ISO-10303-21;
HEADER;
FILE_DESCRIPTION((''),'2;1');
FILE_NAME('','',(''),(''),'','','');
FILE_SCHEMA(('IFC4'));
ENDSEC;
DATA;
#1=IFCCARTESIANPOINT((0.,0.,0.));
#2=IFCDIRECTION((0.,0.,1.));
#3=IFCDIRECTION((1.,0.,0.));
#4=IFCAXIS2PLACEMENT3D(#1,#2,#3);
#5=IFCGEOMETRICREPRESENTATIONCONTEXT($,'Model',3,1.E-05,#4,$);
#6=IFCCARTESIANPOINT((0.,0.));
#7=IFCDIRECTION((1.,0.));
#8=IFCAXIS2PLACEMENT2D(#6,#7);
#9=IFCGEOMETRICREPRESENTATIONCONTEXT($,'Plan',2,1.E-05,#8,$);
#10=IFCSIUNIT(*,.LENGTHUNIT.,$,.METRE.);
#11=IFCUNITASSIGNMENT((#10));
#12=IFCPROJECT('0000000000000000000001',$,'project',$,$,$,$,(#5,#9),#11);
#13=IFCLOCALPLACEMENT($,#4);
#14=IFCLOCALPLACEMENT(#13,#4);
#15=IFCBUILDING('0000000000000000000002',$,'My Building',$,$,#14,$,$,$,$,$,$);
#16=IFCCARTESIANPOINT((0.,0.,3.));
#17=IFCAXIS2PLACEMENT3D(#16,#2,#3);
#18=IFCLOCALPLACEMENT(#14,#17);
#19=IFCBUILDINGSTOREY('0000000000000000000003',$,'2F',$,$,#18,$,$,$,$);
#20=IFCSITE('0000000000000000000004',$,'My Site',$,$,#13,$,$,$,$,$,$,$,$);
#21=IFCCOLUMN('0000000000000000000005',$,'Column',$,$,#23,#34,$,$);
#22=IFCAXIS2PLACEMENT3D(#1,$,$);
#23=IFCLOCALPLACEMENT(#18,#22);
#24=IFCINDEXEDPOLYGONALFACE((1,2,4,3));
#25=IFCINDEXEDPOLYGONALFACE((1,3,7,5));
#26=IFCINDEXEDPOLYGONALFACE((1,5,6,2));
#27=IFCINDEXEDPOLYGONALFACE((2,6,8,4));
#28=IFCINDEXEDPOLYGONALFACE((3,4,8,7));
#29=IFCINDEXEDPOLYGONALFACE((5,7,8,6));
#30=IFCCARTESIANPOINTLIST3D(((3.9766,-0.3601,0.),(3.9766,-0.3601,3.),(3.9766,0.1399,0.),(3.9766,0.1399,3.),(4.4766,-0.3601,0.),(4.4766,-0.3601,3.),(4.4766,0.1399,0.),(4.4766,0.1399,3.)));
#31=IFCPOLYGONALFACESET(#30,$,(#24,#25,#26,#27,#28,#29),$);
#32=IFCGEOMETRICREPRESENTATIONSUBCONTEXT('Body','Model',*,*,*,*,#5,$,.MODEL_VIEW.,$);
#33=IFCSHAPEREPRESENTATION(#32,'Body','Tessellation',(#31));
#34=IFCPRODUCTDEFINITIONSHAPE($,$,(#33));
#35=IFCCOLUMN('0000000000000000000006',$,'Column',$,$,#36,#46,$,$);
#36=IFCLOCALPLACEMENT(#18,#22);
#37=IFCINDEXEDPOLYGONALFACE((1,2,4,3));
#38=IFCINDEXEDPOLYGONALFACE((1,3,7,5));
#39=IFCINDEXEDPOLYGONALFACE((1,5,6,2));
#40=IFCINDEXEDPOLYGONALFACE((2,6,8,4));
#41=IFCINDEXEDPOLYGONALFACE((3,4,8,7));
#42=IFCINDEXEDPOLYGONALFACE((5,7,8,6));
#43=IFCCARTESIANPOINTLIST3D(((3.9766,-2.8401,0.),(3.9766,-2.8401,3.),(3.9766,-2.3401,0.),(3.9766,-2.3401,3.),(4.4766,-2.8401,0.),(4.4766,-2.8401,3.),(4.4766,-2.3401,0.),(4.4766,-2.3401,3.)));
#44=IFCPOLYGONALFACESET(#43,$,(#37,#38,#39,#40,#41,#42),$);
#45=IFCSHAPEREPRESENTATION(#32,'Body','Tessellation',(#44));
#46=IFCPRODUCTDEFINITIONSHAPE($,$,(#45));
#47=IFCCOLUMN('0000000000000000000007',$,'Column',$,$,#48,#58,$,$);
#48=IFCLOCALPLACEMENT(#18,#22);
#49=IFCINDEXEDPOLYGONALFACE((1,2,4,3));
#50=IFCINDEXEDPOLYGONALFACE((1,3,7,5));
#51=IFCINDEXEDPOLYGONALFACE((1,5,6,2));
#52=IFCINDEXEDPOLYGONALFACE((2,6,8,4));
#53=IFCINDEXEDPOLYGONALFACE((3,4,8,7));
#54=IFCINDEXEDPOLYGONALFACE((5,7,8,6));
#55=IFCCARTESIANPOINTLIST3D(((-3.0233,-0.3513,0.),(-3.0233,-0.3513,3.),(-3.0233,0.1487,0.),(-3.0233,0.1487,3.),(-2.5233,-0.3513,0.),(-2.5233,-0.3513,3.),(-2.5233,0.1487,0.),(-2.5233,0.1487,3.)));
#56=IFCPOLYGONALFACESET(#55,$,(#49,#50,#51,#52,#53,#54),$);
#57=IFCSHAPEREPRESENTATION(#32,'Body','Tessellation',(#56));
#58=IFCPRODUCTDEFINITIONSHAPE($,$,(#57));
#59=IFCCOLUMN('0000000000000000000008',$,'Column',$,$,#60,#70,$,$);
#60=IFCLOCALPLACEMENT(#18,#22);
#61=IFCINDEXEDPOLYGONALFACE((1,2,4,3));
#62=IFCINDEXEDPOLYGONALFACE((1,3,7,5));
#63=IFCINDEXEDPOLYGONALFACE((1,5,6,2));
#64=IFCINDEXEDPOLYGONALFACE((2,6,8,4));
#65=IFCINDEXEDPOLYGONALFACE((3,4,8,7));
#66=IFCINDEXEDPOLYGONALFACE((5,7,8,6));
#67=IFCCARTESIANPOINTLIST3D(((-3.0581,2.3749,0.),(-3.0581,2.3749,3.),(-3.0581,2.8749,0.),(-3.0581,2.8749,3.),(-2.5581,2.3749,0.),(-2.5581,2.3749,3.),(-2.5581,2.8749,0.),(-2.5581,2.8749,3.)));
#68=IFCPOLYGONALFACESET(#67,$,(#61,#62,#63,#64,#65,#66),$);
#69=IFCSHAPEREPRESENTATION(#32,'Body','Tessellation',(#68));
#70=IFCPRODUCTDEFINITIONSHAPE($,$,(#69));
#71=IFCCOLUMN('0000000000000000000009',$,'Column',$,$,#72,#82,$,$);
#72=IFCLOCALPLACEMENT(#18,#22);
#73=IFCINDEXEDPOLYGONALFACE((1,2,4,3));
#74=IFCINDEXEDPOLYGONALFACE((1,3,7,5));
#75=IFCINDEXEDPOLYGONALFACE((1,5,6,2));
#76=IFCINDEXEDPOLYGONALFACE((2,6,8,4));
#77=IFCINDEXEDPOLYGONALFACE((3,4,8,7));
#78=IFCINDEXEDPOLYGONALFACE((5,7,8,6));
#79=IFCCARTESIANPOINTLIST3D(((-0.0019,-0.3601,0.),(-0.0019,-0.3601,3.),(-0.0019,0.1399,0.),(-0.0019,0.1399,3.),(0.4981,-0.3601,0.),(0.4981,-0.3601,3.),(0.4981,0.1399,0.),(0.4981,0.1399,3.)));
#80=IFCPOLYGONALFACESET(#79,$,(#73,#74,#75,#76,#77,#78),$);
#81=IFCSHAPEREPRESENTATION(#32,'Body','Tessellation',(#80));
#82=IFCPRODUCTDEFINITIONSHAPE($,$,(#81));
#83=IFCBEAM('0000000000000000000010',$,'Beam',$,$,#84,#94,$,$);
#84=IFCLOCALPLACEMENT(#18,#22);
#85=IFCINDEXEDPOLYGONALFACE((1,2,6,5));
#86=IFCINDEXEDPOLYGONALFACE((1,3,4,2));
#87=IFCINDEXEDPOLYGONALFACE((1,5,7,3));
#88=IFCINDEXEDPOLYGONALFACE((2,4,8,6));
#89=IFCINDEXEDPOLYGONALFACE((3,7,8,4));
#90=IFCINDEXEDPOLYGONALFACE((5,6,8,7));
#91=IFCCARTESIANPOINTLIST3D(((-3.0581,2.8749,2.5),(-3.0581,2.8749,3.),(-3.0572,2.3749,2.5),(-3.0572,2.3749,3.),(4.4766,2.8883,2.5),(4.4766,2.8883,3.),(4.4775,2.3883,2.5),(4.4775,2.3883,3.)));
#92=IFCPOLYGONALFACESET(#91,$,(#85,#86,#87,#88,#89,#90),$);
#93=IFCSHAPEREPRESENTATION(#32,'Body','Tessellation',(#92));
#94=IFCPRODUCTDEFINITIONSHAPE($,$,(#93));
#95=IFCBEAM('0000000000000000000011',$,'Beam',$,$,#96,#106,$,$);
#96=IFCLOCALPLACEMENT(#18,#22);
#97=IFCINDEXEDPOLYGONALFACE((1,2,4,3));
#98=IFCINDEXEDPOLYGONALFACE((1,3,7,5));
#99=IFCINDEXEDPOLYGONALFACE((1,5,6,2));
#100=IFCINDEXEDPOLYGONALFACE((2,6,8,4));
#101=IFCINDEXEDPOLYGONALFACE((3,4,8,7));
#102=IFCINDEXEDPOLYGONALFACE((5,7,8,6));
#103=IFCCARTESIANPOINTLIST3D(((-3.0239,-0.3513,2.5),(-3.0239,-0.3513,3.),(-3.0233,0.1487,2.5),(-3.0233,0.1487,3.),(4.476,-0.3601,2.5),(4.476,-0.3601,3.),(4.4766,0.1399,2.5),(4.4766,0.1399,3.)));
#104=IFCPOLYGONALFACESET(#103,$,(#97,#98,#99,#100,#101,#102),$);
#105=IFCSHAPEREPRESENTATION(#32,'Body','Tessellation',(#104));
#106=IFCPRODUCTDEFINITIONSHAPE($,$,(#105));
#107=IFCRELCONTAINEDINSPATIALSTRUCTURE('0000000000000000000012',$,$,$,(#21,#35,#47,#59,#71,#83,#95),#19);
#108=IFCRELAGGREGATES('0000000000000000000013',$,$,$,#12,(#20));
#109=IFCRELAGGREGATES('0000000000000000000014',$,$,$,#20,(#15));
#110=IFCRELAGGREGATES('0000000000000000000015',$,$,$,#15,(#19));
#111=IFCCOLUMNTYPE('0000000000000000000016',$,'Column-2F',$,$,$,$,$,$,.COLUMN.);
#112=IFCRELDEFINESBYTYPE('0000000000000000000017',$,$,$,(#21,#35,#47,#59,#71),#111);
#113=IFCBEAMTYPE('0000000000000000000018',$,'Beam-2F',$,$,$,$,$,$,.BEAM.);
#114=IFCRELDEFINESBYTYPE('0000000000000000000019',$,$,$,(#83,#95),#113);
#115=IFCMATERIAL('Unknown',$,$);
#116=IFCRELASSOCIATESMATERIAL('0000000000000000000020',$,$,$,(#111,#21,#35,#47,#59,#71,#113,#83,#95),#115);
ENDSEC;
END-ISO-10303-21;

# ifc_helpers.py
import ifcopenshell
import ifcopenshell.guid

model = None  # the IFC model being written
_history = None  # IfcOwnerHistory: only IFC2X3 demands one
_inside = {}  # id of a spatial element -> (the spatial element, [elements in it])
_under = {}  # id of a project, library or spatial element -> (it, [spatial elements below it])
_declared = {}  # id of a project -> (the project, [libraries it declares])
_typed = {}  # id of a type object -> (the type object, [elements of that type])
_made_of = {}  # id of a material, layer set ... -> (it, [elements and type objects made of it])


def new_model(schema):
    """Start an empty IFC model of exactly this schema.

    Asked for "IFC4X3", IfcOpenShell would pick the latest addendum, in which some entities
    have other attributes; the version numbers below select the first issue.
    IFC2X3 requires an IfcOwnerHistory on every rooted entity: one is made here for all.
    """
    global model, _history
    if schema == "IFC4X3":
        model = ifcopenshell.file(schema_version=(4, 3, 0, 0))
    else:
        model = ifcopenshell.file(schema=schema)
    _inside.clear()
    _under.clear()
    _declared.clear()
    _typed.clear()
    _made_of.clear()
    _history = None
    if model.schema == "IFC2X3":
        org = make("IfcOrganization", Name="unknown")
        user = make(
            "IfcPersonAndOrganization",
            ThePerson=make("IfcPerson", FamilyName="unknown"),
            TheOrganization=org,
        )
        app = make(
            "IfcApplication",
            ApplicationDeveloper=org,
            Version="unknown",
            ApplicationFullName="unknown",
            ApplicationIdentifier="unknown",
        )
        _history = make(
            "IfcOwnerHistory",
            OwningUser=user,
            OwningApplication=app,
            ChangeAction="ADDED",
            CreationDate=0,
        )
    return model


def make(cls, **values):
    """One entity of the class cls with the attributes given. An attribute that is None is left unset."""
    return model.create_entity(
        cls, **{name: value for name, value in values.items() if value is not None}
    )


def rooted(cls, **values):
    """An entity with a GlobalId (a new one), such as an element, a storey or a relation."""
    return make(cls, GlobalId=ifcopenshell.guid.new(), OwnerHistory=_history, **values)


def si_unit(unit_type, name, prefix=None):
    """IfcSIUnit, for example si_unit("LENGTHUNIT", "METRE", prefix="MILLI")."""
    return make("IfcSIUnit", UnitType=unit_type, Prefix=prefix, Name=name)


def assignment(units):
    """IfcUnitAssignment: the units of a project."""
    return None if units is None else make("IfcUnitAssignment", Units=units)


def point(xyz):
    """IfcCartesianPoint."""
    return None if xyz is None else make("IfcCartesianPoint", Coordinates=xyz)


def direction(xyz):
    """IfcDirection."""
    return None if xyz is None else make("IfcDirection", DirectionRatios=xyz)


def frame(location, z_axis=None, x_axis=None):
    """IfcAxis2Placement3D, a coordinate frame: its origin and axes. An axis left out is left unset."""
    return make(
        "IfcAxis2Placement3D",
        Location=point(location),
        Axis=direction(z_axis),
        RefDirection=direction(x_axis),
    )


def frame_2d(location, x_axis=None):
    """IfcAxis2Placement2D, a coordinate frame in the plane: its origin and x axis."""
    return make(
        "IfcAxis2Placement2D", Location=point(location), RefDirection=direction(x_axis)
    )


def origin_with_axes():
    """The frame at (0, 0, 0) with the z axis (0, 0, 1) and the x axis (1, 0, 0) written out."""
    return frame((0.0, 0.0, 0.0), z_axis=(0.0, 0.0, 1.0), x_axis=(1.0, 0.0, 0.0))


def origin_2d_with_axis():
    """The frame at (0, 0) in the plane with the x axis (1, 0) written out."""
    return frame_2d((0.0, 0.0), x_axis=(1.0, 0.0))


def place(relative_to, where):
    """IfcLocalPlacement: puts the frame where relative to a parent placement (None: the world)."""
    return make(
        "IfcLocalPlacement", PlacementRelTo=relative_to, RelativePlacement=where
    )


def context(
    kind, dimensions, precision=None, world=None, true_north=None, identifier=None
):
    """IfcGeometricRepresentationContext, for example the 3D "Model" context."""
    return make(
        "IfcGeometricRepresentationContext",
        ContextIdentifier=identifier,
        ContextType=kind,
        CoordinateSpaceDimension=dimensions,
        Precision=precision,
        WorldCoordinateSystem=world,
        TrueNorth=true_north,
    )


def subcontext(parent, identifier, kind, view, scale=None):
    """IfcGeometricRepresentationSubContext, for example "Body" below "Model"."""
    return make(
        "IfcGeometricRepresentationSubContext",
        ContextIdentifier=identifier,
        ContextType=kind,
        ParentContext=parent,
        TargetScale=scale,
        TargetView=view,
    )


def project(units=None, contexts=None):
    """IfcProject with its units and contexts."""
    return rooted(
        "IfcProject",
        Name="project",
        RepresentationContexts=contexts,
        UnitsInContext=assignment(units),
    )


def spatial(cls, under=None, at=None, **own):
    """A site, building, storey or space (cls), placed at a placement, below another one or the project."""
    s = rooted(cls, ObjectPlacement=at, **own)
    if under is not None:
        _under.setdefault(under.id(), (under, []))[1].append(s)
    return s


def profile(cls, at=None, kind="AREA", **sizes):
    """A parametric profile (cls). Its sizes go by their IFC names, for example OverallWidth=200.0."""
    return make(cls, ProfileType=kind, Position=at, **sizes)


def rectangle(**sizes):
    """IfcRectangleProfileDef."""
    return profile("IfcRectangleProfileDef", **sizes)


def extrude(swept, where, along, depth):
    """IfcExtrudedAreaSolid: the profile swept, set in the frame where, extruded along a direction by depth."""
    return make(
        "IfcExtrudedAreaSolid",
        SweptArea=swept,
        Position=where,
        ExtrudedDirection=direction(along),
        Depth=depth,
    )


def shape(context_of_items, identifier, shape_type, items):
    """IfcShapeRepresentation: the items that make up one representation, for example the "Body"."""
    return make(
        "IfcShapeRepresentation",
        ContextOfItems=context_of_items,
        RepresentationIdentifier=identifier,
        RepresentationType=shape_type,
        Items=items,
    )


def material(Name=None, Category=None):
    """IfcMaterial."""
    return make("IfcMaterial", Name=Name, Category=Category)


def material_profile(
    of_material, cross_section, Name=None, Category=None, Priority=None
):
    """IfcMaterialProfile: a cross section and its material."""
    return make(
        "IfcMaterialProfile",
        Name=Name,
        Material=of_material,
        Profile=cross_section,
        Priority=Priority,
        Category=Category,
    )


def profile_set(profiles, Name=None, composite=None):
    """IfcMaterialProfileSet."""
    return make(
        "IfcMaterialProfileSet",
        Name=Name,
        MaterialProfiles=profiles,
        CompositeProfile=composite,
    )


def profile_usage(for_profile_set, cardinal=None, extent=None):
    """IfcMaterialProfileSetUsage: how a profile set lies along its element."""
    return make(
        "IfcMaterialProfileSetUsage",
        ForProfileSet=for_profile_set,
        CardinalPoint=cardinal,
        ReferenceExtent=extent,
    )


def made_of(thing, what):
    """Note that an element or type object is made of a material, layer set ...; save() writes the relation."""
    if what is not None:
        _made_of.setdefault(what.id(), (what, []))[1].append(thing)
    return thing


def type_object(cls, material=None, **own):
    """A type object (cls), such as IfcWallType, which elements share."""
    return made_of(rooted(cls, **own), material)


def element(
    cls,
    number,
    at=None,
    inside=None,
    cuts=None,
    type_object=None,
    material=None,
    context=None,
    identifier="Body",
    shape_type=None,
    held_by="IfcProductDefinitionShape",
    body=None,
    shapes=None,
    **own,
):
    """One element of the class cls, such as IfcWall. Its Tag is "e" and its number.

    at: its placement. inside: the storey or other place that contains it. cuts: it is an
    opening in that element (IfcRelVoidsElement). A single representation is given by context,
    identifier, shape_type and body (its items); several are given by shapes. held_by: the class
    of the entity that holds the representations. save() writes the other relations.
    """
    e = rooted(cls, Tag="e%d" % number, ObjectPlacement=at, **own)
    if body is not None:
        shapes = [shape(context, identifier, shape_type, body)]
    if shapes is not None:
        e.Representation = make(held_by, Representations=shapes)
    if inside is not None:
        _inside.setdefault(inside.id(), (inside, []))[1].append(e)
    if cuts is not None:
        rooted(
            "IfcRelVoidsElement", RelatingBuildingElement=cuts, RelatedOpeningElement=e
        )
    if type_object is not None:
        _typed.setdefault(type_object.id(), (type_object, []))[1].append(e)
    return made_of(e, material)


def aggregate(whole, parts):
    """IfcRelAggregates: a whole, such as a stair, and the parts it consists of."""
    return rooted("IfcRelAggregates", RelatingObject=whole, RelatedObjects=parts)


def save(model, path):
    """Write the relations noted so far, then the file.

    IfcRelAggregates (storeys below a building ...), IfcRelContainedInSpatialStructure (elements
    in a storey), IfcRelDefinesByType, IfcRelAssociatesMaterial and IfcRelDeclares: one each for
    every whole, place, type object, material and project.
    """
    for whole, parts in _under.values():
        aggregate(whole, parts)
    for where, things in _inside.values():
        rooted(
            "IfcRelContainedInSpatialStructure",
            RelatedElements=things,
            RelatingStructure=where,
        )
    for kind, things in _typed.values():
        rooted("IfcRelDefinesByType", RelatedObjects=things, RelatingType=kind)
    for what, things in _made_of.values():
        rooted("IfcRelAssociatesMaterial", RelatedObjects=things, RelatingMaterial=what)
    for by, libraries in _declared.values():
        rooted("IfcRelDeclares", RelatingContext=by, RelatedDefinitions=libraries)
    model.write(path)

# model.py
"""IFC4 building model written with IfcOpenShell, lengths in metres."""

from ifc_helpers import new_model, si_unit, frame, origin_with_axes, origin_2d_with_axis, place, context, subcontext, project, spatial, rectangle, extrude, material, material_profile, profile_set, profile_usage, type_object, element, save


model = new_model("IFC4")

# Units and contexts
model_context = context("Model", 3, precision=1e-05, world=origin_with_axes())
plan_context = context("Plan", 2, precision=1e-05, world=origin_2d_with_axis())
body_context_1 = subcontext(model_context, "Body", "Model", "MODEL_VIEW")
ifc_project = project(units=[si_unit("LENGTHUNIT", "METRE")], contexts=[model_context, plan_context])

# Site, building, storey
site_placement = place(None, origin_with_axes())
site = spatial("IfcSite", under=ifc_project, at=site_placement, Name="My Site")
building_placement = place(site_placement, origin_with_axes())
building = spatial("IfcBuilding", under=site, at=building_placement, Name="My Building")
storey_placement = place(building_placement, frame((0.0, 0.0, 3.0), z_axis=(0.0, 0.0, 1.0), x_axis=(1.0, 0.0, 0.0)))
storey = spatial("IfcBuildingStorey", under=building, at=storey_placement, Name="2F")

# Columns
ifc_material = material(Name="Unknown")
ifc_material_profile_1 = material_profile(ifc_material, rectangle(XDim=0.5, YDim=0.5))
ifc_profile_set_1 = profile_set([ifc_material_profile_1])
ifc_profile_usage_1 = profile_usage(ifc_profile_set_1, cardinal=7)
column_type = type_object("IfcColumnType", Name="Column-2F", PredefinedType="COLUMN", material=ifc_profile_set_1)
column_1_placement = place(storey_placement, frame((4.4766, 0.1399, 0.0), z_axis=(0.0, 0.0, 1.0), x_axis=(1.0, 0.0, 0.0)))
element("IfcColumn", 1, at=column_1_placement, inside=storey, type_object=column_type, material=ifc_profile_usage_1, Name="Column", context=body_context_1, shape_type="SweptSolid", body=[
    extrude(rectangle(XDim=0.5, YDim=0.5), frame((-0.25, -0.25, 0.0), z_axis=(0.0, 0.0, 1.0), x_axis=(1.0, 0.0, 0.0)), (0.0, 0.0, 1.0), 3.0),
])
ifc_profile_usage_2 = profile_usage(ifc_profile_set_1, cardinal=7)
column_2_placement = place(storey_placement, frame((4.4766, -2.3401, 0.0), z_axis=(0.0, 0.0, 1.0), x_axis=(1.0, 0.0, 0.0)))
element("IfcColumn", 2, at=column_2_placement, inside=storey, type_object=column_type, material=ifc_profile_usage_2, Name="Column", context=body_context_1, shape_type="SweptSolid", body=[
    extrude(rectangle(XDim=0.5, YDim=0.5), frame((-0.25, -0.25, 0.0), z_axis=(0.0, 0.0, 1.0), x_axis=(1.0, 0.0, 0.0)), (0.0, 0.0, 1.0), 3.0),
])
ifc_profile_usage_3 = profile_usage(ifc_profile_set_1, cardinal=7)
column_3_placement = place(storey_placement, frame((-2.5233, 0.1487, 0.0), z_axis=(0.0, 0.0, 1.0), x_axis=(1.0, 0.0, 0.0)))
element("IfcColumn", 3, at=column_3_placement, inside=storey, type_object=column_type, material=ifc_profile_usage_3, Name="Column", context=body_context_1, shape_type="SweptSolid", body=[
    extrude(rectangle(XDim=0.5, YDim=0.5), frame((-0.25, -0.25, 0.0), z_axis=(0.0, 0.0, 1.0), x_axis=(1.0, 0.0, 0.0)), (0.0, 0.0, 1.0), 3.0),
])
ifc_profile_usage_4 = profile_usage(ifc_profile_set_1, cardinal=7)
column_4_placement = place(storey_placement, frame((-2.5581, 2.8749, 0.0), z_axis=(0.0, 0.0, 1.0), x_axis=(1.0, 0.0, 0.0)))
element("IfcColumn", 4, at=column_4_placement, inside=storey, type_object=column_type, material=ifc_profile_usage_4, Name="Column", context=body_context_1, shape_type="SweptSolid", body=[
    extrude(rectangle(XDim=0.5, YDim=0.5), frame((-0.25, -0.25, 0.0), z_axis=(0.0, 0.0, 1.0), x_axis=(1.0, 0.0, 0.0)), (0.0, 0.0, 1.0), 3.0),
])
ifc_profile_usage_5 = profile_usage(ifc_profile_set_1, cardinal=7)
column_5_placement = place(storey_placement, frame((0.4981, 0.1399, 0.0), z_axis=(0.0, 0.0, 1.0), x_axis=(1.0, 0.0, 0.0)))
element("IfcColumn", 5, at=column_5_placement, inside=storey, type_object=column_type, material=ifc_profile_usage_5, Name="Column", context=body_context_1, shape_type="SweptSolid", body=[
    extrude(rectangle(XDim=0.5, YDim=0.5), frame((-0.25, -0.25, 0.0), z_axis=(0.0, 0.0, 1.0), x_axis=(1.0, 0.0, 0.0)), (0.0, 0.0, 1.0), 3.0),
])

# Beams
ifc_material_profile_2 = material_profile(ifc_material, rectangle(XDim=0.5, YDim=0.5))
ifc_profile_set_2 = profile_set([ifc_material_profile_2])
ifc_profile_usage_6 = profile_usage(ifc_profile_set_2, cardinal=7)
beam_type = type_object("IfcBeamType", Name="Beam-2F", PredefinedType="BEAM", material=ifc_profile_set_2)
beam_1_placement = place(storey_placement, frame((-3.0581, 2.8749, 3.0), z_axis=(0.999998, 0.001779, 0.0), x_axis=(-0.001779, 0.999998, 0.0)))
element("IfcBeam", 6, at=beam_1_placement, inside=storey, type_object=beam_type, material=ifc_profile_usage_6, Name="Beam", context=body_context_1, shape_type="SweptSolid", body=[
    extrude(rectangle(XDim=0.5, YDim=0.5), frame((-0.25, -0.25, 0.0), z_axis=(0.0, 0.0, 1.0), x_axis=(1.0, 0.0, 0.0)), (0.0, 0.0, 1.0), 7.5347),
])
ifc_profile_usage_7 = profile_usage(ifc_profile_set_2, cardinal=7)
beam_2_placement = place(storey_placement, frame((-3.0233, 0.1487, 3.0), z_axis=(0.999999, -0.001175, 0.0), x_axis=(0.001175, 0.999999, 0.0)))
element("IfcBeam", 7, at=beam_2_placement, inside=storey, type_object=beam_type, material=ifc_profile_usage_7, Name="Beam", context=body_context_1, shape_type="SweptSolid", body=[
    extrude(rectangle(XDim=0.5, YDim=0.5), frame((-0.25, -0.25, 0.0), z_axis=(0.0, 0.0, 1.0), x_axis=(1.0, 0.0, 0.0)), (0.0, 0.0, 1.0), 7.4999),
])

save(model, "model.ifc")
